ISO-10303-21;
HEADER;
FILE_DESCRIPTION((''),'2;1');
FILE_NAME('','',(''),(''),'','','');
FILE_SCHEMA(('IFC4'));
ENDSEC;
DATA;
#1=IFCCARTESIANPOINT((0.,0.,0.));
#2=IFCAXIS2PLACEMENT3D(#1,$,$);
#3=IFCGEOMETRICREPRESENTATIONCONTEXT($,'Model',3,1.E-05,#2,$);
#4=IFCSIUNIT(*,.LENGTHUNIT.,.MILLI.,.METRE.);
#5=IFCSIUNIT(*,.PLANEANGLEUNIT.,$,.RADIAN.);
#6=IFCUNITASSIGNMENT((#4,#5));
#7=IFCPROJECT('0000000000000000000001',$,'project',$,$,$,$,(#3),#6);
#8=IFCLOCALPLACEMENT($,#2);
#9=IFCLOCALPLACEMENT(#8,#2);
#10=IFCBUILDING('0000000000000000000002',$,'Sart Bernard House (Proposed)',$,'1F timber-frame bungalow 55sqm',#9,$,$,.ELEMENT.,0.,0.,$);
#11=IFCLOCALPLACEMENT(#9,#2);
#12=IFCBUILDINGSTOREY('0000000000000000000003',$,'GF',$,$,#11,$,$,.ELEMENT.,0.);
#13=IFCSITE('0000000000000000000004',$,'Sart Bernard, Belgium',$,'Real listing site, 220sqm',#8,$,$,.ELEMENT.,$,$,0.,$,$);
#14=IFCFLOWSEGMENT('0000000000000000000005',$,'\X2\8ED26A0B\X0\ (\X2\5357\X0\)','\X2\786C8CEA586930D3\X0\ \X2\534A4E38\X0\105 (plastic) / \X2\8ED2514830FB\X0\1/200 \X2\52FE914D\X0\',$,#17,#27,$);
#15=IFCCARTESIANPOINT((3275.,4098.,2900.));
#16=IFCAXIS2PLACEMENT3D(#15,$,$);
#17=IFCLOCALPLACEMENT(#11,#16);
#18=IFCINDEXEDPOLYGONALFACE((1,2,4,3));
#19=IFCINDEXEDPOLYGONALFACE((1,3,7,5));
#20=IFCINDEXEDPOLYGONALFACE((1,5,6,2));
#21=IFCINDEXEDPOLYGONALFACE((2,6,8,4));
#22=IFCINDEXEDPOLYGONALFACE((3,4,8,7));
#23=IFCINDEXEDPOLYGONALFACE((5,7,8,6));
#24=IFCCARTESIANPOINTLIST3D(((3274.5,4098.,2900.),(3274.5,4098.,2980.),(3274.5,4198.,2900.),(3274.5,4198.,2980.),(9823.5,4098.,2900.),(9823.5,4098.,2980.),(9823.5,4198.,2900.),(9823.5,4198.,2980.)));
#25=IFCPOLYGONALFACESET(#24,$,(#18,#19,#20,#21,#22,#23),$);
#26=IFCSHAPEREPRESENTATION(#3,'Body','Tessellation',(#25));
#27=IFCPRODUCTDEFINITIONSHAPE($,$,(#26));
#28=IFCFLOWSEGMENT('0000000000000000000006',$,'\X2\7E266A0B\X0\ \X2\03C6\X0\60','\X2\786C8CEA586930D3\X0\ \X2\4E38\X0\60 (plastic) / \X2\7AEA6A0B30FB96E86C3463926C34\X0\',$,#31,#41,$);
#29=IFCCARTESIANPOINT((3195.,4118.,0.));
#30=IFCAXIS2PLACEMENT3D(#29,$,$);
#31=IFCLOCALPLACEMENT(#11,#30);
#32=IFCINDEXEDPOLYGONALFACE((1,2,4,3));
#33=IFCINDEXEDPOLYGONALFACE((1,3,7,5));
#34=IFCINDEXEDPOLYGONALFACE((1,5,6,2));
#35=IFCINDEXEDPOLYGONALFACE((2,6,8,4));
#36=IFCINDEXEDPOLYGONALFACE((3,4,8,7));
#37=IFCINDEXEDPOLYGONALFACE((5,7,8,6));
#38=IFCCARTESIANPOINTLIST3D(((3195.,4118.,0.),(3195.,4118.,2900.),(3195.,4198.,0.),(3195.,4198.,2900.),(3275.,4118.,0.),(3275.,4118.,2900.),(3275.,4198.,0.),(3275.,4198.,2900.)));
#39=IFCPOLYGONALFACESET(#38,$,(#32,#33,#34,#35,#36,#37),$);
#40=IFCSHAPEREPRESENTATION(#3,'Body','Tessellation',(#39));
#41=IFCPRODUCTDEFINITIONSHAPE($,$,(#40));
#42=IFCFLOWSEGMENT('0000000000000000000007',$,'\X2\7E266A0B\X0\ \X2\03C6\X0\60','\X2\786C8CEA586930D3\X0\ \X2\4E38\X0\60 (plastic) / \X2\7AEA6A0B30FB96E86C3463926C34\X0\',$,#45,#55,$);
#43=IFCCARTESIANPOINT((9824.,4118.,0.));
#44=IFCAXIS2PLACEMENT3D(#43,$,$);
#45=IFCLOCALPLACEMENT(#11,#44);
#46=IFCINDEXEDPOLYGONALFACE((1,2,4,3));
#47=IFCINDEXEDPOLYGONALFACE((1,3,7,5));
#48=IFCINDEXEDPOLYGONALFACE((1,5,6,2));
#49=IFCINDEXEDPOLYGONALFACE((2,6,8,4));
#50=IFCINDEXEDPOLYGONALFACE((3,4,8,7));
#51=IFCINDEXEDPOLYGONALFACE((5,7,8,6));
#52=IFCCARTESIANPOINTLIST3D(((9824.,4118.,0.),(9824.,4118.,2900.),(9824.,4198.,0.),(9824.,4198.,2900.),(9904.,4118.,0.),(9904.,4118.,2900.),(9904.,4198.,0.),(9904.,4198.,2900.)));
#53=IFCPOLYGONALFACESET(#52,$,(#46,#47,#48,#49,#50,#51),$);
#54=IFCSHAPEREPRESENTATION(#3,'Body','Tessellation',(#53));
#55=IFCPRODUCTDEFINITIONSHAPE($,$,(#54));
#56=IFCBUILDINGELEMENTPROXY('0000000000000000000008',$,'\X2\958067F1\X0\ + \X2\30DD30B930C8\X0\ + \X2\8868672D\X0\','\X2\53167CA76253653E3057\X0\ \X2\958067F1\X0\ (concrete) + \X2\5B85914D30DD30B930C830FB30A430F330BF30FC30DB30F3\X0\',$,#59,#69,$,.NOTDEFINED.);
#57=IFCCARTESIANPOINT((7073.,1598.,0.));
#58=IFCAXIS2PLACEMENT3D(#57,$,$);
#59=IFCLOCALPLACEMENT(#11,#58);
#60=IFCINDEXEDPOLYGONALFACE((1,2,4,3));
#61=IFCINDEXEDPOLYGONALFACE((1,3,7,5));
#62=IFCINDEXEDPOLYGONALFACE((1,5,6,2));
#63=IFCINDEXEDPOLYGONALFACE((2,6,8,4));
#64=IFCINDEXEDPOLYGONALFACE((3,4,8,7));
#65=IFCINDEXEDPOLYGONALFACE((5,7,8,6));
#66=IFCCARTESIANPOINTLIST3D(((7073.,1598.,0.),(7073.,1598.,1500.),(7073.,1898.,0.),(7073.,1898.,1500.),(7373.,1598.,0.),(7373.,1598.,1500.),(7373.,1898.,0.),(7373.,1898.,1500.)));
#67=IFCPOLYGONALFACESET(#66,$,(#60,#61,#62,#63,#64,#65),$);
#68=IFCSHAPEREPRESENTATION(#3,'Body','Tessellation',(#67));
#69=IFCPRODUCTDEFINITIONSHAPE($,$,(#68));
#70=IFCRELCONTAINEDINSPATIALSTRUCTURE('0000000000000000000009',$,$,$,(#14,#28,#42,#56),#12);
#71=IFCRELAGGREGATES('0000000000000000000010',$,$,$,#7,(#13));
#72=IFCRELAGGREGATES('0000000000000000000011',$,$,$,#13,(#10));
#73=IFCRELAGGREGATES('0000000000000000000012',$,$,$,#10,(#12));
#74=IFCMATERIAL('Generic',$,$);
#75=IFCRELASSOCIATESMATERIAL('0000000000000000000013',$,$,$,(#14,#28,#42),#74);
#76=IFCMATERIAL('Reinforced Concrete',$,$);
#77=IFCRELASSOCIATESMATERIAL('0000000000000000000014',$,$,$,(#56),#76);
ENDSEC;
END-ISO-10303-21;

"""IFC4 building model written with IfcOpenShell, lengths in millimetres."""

from ifc_helpers import new_model, si_unit, frame, frame_2d, origin, place, context, project, spatial, rectangle, extrude, material, element, save


model = new_model("IFC4")

# Units and contexts
model_context = context("Model", 3, precision=1e-05, world=origin())
ifc_project = project(units=[si_unit("LENGTHUNIT", "METRE", prefix="MILLI"), si_unit("PLANEANGLEUNIT", "RADIAN")], contexts=[model_context])

# Site, building, storey
site_placement = place(None, origin())
site = spatial("IfcSite", under=ifc_project, at=site_placement, Name="Sart Bernard, Belgium", ObjectType="Real listing site, 220sqm", CompositionType="ELEMENT", RefElevation=0.0)
building_placement = place(site_placement, origin())
building = spatial("IfcBuilding", under=site, at=building_placement, Name="Sart Bernard House (Proposed)", ObjectType="1F timber-frame bungalow 55sqm", CompositionType="ELEMENT", ElevationOfRefHeight=0.0, ElevationOfTerrain=0.0)
storey_placement = place(building_placement, origin())
storey = spatial("IfcBuildingStorey", under=building, at=storey_placement, Name="GF", CompositionType="ELEMENT", Elevation=0.0)

# Shared definitions
ifc_material_1 = material(Name="Reinforced Concrete")

# Shared definitions
ifc_material_2 = material(Name="Generic")

# Flow segments
flow_segment_1_placement = place(storey_placement, frame((3275.0, 4098.0, 2900.0)))
element("IfcFlowSegment", 1, at=flow_segment_1_placement, inside=storey, material=ifc_material_2, Name="軒樋 (南)", Description="硬質塩ビ 半丸105 (plastic) / 軒先・1/200 勾配", context=model_context, shape_type="SweptSolid", body=[
    extrude(rectangle(XDim=6549.0, YDim=100.0, at=frame_2d((3274.0, 50.0))), frame((3275.0, 4098.0, 2900.0)), (0.0, 0.0, 1.0), 80.0),
])
flow_segment_2_placement = place(storey_placement, frame((3195.0, 4118.0, 0.0)))
element("IfcFlowSegment", 2, at=flow_segment_2_placement, inside=storey, material=ifc_material_2, Name="縦樋 φ60", Description="硬質塩ビ 丸60 (plastic) / 竪樋・雨水排水", context=model_context, shape_type="SweptSolid", body=[
    extrude(rectangle(XDim=80.0, YDim=80.0, at=frame_2d((40.0, 40.0))), frame((3195.0, 4118.0, 0.0)), (0.0, 0.0, 1.0), 2900.0),
])
flow_segment_3_placement = place(storey_placement, frame((9824.0, 4118.0, 0.0)))
element("IfcFlowSegment", 3, at=flow_segment_3_placement, inside=storey, material=ifc_material_2, Name="縦樋 φ60", Description="硬質塩ビ 丸60 (plastic) / 竪樋・雨水排水", context=model_context, shape_type="SweptSolid", body=[
    extrude(rectangle(XDim=80.0, YDim=80.0, at=frame_2d((40.0, 40.0))), frame((9824.0, 4118.0, 0.0)), (0.0, 0.0, 1.0), 2900.0),
])

# Building element proxy
proxy_placement = place(storey_placement, frame((7073.0, 1598.0, 0.0)))
element("IfcBuildingElementProxy", 4, at=proxy_placement, inside=storey, material=ifc_material_1, Name="門柱 + ポスト + 表札", Description="化粧打放し 門柱 (concrete) + 宅配ポスト・インターホン", PredefinedType="NOTDEFINED", context=model_context, shape_type="SweptSolid", body=[
    extrude(rectangle(XDim=300.0, YDim=300.0, at=frame_2d((150.0, 150.0))), frame((7073.0, 1598.0, 0.0)), (0.0, 0.0, 1.0), 1500.0),
])

save(model, "model.ifc")
